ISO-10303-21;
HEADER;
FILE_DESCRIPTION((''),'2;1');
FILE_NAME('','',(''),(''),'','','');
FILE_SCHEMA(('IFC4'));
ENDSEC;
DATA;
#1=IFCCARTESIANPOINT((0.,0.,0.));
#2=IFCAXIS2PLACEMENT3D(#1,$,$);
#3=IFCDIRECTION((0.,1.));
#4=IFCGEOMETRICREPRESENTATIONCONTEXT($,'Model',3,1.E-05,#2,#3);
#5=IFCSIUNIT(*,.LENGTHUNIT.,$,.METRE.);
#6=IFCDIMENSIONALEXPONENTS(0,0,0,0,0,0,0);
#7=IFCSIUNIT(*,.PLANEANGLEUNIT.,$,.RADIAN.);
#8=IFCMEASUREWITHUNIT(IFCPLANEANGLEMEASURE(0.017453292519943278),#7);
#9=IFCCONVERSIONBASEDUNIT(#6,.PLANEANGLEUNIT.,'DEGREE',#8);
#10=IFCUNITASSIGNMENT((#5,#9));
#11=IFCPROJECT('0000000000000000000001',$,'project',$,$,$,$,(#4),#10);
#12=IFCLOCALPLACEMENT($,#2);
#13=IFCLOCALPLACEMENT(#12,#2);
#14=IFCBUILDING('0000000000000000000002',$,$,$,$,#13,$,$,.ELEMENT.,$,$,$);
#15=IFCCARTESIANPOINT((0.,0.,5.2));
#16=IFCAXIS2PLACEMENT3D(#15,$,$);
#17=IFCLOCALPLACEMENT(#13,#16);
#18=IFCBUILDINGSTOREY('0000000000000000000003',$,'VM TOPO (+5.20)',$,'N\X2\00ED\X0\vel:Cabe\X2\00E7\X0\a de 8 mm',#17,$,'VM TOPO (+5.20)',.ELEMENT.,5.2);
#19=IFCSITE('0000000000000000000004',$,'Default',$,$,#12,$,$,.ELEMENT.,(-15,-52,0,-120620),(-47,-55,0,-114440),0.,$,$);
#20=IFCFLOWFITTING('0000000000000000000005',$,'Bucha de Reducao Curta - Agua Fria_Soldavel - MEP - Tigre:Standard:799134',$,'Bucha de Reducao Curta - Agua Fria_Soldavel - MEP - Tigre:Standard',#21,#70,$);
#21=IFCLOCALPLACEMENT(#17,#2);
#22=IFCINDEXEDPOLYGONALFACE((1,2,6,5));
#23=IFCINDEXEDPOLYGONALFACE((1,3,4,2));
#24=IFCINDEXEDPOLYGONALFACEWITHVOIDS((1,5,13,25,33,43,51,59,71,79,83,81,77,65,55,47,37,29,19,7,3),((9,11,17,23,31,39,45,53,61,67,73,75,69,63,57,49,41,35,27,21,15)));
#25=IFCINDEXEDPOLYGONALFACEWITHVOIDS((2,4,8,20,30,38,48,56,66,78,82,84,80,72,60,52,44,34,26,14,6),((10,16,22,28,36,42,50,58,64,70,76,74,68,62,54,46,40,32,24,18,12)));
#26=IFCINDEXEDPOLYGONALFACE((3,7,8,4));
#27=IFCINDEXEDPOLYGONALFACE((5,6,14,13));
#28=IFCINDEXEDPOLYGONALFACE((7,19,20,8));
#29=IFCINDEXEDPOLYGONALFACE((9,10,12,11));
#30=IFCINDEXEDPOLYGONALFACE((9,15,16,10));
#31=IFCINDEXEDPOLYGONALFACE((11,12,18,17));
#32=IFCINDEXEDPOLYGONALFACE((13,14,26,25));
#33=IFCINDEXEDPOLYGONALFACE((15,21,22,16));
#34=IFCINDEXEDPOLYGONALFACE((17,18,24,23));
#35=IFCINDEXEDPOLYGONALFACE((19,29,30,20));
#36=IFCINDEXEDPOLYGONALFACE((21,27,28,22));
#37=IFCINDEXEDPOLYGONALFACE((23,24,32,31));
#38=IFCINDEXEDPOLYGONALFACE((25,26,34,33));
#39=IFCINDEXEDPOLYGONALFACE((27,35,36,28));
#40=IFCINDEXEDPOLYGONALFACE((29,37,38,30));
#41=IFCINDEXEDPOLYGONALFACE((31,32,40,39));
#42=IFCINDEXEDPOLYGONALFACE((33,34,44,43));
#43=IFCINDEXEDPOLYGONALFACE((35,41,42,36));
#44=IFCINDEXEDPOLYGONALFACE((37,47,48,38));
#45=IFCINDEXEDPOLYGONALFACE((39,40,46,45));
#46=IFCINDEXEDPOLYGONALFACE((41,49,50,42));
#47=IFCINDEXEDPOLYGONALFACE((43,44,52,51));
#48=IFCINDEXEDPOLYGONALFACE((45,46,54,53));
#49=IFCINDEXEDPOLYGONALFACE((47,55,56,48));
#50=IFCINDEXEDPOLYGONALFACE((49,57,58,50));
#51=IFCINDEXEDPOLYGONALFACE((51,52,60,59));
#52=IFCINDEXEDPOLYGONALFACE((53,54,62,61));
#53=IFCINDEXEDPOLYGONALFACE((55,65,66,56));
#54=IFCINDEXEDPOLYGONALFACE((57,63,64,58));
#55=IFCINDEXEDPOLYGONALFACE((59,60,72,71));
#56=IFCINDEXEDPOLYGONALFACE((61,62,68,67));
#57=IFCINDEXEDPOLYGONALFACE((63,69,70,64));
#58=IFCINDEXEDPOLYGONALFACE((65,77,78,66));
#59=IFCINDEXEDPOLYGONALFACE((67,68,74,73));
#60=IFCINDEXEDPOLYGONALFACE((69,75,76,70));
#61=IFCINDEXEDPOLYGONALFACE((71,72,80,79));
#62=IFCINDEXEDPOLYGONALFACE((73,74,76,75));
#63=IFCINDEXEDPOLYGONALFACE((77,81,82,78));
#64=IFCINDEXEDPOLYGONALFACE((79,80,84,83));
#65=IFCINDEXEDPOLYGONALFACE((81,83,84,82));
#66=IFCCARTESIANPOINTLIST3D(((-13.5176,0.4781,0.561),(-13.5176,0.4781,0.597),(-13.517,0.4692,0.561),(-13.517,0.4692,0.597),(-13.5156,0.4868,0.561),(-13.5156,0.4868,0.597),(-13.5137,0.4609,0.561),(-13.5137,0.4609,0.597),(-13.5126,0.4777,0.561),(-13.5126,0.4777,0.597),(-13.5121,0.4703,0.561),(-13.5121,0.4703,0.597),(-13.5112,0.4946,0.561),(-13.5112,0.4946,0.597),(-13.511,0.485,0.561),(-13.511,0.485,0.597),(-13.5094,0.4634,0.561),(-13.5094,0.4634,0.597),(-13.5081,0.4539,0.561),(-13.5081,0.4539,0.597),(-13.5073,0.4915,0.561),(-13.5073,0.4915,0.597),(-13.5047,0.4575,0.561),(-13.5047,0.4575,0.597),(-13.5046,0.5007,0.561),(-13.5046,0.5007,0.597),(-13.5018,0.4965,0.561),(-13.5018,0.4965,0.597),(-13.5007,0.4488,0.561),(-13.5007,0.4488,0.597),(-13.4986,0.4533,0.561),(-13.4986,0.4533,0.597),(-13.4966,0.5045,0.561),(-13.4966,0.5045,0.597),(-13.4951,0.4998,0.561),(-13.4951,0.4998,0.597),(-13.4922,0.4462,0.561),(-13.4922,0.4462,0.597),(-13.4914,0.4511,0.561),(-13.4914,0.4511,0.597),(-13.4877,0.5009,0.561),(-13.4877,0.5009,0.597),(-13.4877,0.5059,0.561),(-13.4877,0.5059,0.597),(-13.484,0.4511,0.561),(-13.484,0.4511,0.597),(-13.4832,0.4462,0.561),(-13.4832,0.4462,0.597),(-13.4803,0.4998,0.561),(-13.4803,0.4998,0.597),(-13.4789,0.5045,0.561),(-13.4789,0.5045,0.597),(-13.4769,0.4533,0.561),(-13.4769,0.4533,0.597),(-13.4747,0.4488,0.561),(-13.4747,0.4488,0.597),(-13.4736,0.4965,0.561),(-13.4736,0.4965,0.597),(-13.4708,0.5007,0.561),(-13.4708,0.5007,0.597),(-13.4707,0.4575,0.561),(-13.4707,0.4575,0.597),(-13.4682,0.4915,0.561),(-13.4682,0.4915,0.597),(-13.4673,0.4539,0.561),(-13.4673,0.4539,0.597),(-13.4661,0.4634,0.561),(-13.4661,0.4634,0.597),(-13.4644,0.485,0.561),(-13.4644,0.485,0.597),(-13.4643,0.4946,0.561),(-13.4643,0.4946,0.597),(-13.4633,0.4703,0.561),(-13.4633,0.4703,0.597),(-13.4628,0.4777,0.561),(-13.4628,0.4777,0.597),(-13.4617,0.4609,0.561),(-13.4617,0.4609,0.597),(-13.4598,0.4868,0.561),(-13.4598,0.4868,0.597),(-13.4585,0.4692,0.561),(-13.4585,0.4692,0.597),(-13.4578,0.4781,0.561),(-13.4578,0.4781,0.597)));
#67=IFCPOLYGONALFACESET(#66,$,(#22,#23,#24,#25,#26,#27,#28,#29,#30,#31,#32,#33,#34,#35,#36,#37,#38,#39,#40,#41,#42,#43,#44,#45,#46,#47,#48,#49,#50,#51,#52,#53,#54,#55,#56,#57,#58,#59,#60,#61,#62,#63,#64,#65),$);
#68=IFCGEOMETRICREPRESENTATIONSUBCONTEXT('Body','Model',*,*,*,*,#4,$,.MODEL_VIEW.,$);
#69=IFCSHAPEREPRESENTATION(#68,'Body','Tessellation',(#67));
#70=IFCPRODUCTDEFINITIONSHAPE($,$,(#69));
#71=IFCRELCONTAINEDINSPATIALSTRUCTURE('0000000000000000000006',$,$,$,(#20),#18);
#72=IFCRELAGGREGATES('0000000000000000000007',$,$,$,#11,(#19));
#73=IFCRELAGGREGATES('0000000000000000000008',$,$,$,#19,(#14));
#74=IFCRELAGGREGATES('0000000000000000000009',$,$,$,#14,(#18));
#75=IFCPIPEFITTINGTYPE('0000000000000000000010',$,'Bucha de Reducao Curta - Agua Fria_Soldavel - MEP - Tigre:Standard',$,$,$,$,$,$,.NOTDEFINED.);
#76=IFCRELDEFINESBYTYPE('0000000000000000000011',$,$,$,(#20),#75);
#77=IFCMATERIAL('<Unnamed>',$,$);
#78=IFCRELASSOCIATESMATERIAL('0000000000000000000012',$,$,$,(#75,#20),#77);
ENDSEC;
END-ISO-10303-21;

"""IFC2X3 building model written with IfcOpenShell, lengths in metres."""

from ifc_helpers import new_model, entity, si_unit, converted_unit, direction, frame, frame_2d, origin, place, context, subcontext, project, spatial, hollow_circle, extrude, source, transform, mapped, material, type_object, type_shapes, element, save


model = new_model("IFC2X3")

# Units and contexts
model_context = context("Model", 3, precision=1e-05, world=origin(), true_north=direction((0.0, 1.0)))
body_context = subcontext(model_context, "Body", "Model", "MODEL_VIEW")
ifc_project = project(units=[si_unit("LENGTHUNIT", "METRE"), converted_unit("PLANEANGLEUNIT", "DEGREE", entity("IfcPlaneAngleMeasure", 0.017453292519943278), si_unit("PLANEANGLEUNIT", "RADIAN"), dimensions=[0, 0, 0, 0, 0, 0, 0])], contexts=[model_context])

# Site, building, storey
site_placement = place(None, origin())
site = spatial("IfcSite", under=ifc_project, at=site_placement, Name="Default", CompositionType="ELEMENT", RefLatitude=(-15, -52, 0, -120620), RefLongitude=(-47, -55, 0, -114440), RefElevation=0.0)
building_placement = place(site_placement, origin())
building = spatial("IfcBuilding", under=site, at=building_placement, CompositionType="ELEMENT")
storey_placement = place(building_placement, frame((0.0, 0.0, 5.2)))
storey = spatial("IfcBuildingStorey", under=building, at=storey_placement, Name="VM TOPO (+5.20)", ObjectType="Nível:Cabeça de 8 mm", LongName="VM TOPO (+5.20)", CompositionType="ELEMENT", Elevation=5.2)

# Flow fitting
ifc_material_1 = material(Name="<Unnamed>")
pipe_fitting_type_1 = type_object("IfcPipeFittingType", Name="Bucha de Reducao Curta - Agua Fria_Soldavel - MEP - Tigre:Standard", PredefinedType="NOTDEFINED", material=ifc_material_1)
shared_shape_1 = source(origin(), body_context, "Body", "SweptSolid", [
    extrude(hollow_circle(Radius=0.03, WallThickness=0.005, at=frame_2d((0.0, 0.0), x_axis=(1.0, 0.0))), frame((0.0, 0.0, 0.0), z_axis=(1.0, 0.0, 0.0), x_axis=(0.0, 1.0, 0.0)), (0.0, 0.0, 1.0), 0.036),
])
type_shapes(pipe_fitting_type_1, [shared_shape_1])
for number, where, z_axis, x_axis, name in (
    (1, (-13.4877, 0.4759, 0.597), (1.0, 0.0, 0.0), (0.0, 0.0, -1.0), "Bucha de Reducao Curta - Agua Fria_Soldavel - MEP - Tigre:Standard:799134"),
):
    element("IfcFlowFitting", number, at=place(storey_placement, frame(where, z_axis=z_axis, x_axis=x_axis)), inside=storey, type_object=pipe_fitting_type_1, material=ifc_material_1, Name=name, ObjectType="Bucha de Reducao Curta - Agua Fria_Soldavel - MEP - Tigre:Standard", context=body_context, shape_type="MappedRepresentation", body=[
        mapped(shared_shape_1, transform((0.0, 0.0, 0.0), scale=1.0)),
    ])

save(model, "model.ifc")
